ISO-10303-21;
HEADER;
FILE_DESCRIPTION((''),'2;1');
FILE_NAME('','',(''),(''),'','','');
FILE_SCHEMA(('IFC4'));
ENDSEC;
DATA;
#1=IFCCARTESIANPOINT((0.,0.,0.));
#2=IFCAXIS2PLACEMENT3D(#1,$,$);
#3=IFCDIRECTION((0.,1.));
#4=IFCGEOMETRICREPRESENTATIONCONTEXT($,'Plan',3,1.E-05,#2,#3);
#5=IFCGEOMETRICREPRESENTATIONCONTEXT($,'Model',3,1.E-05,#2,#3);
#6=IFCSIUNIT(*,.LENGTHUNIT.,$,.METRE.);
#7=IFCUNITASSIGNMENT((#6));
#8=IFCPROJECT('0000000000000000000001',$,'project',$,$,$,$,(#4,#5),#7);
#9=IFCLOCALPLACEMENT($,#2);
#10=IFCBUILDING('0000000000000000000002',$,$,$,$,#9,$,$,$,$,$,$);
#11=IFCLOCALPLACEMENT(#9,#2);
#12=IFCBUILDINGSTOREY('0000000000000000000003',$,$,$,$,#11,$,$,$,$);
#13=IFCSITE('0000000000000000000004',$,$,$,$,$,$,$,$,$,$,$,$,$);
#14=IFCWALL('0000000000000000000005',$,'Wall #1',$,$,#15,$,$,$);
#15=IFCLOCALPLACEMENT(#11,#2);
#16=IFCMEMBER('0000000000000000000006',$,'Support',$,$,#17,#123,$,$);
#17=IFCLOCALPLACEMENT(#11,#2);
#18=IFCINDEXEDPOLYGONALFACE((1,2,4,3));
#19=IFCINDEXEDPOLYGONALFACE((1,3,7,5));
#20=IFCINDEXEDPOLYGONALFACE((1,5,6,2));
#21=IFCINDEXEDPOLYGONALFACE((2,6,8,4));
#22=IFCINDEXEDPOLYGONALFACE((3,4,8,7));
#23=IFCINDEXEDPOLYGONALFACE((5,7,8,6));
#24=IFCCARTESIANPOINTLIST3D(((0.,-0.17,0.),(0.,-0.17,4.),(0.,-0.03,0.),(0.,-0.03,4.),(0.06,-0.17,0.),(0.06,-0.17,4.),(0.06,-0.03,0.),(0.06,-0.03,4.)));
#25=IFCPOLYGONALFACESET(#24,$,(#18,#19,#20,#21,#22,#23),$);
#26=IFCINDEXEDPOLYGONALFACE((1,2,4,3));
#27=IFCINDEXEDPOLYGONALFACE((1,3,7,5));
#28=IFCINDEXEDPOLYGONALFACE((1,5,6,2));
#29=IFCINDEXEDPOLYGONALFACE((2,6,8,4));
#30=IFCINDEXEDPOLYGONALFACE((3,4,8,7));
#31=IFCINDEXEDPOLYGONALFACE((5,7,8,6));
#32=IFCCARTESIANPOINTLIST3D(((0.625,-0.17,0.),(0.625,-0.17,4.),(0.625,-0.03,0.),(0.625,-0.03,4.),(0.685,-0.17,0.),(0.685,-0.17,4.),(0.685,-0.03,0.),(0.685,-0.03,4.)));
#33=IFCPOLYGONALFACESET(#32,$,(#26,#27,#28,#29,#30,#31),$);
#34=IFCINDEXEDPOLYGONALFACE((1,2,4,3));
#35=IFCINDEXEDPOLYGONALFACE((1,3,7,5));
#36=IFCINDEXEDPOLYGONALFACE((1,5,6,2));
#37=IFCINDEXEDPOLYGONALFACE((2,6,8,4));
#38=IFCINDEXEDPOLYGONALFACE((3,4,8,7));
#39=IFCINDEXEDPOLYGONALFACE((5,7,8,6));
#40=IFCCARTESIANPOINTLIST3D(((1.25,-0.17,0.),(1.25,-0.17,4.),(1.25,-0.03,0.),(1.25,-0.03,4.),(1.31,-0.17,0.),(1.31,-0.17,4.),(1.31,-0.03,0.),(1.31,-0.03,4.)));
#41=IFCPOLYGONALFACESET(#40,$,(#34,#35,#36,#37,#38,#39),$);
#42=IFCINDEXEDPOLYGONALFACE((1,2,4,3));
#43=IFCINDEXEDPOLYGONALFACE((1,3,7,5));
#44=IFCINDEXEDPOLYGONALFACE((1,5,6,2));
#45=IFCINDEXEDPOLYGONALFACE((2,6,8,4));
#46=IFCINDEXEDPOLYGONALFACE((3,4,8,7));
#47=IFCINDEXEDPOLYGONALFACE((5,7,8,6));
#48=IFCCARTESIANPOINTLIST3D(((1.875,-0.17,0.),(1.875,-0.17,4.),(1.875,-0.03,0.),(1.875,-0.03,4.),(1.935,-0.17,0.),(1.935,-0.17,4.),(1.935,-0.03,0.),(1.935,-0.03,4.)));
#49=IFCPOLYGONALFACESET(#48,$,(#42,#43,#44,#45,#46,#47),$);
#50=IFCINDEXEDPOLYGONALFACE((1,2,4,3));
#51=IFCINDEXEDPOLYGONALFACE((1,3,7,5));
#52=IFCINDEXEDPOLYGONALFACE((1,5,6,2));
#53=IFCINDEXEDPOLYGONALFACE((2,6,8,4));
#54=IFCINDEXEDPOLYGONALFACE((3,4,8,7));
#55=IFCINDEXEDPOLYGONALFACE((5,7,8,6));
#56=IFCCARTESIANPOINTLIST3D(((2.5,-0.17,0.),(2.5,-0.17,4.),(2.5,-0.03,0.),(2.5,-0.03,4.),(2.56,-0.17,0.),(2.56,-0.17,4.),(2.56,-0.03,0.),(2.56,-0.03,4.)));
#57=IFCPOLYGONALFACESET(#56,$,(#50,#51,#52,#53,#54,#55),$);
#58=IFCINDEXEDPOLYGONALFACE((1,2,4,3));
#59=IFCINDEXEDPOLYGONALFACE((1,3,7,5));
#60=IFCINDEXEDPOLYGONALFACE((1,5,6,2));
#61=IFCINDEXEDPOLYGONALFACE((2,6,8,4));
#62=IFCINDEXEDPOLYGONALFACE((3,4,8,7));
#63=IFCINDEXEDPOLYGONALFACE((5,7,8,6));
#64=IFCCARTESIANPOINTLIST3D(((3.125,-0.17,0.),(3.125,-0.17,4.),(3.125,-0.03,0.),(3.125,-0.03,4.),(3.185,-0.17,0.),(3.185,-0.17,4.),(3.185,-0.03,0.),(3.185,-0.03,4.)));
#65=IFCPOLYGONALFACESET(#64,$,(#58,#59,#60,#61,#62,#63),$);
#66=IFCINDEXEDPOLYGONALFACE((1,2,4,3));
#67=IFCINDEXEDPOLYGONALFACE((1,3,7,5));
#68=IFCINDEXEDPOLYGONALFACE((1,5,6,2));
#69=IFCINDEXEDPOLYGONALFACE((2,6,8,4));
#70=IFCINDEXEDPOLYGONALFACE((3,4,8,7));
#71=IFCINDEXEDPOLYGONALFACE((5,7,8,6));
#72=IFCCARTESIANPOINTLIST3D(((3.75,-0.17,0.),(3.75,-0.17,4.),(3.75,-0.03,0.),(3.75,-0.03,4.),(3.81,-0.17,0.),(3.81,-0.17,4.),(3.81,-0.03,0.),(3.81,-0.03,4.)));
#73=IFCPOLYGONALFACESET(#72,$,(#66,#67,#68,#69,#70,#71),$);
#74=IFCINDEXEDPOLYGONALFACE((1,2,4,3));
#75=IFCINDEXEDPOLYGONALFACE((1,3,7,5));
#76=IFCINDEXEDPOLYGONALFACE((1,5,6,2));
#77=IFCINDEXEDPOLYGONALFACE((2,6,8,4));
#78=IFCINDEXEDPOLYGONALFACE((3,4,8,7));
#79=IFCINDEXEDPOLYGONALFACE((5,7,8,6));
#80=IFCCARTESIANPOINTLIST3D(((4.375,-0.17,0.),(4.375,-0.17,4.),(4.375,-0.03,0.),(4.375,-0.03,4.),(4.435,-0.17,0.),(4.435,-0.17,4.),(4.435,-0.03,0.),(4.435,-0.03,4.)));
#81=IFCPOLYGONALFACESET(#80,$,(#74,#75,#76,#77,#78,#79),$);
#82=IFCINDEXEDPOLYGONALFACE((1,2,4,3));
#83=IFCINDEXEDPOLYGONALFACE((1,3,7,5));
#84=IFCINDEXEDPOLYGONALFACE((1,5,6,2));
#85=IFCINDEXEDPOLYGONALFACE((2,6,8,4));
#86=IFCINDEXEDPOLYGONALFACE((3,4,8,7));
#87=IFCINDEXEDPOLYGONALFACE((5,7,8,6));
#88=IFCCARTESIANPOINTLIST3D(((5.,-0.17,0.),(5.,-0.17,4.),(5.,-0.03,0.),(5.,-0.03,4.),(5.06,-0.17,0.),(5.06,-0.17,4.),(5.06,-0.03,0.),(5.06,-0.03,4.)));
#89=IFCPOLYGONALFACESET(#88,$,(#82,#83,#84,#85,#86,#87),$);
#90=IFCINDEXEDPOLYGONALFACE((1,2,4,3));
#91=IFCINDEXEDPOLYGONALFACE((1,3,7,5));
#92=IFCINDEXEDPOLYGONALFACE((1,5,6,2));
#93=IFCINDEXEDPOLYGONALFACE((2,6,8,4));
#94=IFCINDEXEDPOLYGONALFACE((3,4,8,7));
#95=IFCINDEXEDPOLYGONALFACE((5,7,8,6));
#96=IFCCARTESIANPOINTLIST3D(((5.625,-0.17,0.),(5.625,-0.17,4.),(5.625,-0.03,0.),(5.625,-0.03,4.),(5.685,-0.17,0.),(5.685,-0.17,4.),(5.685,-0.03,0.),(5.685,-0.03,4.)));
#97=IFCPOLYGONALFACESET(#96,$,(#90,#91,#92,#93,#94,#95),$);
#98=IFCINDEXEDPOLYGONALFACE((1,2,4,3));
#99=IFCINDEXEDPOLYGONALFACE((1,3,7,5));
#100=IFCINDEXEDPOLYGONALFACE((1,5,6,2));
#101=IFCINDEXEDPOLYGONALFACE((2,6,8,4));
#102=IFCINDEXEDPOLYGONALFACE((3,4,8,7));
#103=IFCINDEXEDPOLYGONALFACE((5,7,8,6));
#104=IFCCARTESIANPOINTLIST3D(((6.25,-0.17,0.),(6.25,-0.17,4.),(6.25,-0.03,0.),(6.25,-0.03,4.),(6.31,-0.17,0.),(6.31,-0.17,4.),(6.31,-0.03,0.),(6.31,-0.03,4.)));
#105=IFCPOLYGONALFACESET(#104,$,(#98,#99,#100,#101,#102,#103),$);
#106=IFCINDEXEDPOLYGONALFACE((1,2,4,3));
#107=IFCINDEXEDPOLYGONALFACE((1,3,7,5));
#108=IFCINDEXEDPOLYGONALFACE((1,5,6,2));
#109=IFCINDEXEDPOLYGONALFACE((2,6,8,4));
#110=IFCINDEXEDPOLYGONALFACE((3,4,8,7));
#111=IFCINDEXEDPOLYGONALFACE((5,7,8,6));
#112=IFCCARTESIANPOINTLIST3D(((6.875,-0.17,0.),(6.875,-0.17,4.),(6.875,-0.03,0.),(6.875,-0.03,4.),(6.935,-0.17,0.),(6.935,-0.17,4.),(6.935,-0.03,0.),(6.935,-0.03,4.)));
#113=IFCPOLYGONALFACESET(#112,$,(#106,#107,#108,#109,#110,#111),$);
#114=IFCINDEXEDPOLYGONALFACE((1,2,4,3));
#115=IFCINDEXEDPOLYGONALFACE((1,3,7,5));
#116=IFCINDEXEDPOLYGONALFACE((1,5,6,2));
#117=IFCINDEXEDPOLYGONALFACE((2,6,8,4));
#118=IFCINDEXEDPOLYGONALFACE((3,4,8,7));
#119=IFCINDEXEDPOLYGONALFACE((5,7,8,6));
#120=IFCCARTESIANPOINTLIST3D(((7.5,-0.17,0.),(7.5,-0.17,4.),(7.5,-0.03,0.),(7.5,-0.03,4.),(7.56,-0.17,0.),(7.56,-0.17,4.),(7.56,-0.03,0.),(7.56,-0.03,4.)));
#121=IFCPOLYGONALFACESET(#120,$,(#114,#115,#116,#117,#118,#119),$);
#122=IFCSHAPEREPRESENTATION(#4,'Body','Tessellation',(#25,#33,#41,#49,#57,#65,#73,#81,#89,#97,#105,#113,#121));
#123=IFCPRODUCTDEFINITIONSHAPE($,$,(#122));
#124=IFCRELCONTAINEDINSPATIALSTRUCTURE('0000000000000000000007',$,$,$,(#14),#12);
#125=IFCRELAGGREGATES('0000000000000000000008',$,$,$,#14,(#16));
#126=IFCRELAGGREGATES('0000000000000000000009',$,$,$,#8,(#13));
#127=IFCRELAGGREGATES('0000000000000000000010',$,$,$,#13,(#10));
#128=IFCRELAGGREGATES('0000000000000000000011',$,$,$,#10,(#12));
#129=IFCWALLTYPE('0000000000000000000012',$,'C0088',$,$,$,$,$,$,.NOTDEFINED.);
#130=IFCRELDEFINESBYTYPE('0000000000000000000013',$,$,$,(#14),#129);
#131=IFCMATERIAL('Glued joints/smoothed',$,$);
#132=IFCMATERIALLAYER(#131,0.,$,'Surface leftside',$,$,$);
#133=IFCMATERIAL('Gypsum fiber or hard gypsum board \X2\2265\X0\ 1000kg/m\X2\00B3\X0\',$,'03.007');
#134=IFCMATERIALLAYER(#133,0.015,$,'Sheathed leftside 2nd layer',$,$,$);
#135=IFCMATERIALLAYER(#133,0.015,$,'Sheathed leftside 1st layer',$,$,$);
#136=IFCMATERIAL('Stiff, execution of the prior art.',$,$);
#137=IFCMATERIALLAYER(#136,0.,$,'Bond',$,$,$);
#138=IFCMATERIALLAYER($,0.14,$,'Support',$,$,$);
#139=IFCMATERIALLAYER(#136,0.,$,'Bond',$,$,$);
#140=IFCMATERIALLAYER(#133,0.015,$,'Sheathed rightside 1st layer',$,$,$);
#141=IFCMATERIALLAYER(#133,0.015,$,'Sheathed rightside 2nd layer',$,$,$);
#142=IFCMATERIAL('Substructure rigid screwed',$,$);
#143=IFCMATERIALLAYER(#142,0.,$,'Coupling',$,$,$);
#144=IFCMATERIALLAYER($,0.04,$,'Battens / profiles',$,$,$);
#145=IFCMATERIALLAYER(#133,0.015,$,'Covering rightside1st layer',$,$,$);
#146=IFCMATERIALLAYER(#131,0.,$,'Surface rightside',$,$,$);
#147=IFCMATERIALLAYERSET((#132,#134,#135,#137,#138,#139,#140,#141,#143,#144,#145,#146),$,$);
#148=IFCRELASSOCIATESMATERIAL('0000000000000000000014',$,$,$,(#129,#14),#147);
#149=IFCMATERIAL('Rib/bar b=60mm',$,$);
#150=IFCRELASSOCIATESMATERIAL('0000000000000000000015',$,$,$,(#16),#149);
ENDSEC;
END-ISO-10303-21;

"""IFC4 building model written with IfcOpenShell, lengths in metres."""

from ifc_helpers import new_model, si_unit, direction, frame, frame_2d, origin, place, context, project, spatial, rectangle, extrude, material, layer, layer_set, type_object, element, aggregate, save


model = new_model("IFC4")

# Units and contexts
plan_context = context("Plan", 3, precision=1e-05, world=origin(), true_north=direction((0.0, 1.0)))
model_context = context("Model", 3, precision=1e-05, world=origin(), true_north=direction((0.0, 1.0)))
ifc_project = project(units=[si_unit("LENGTHUNIT", "METRE")], contexts=[plan_context, model_context])

# Site, building, storey
site = spatial("IfcSite", under=ifc_project)
building_placement = place(None, origin())
building = spatial("IfcBuilding", under=site, at=building_placement)
storey_placement = place(building_placement, origin())
storey = spatial("IfcBuildingStorey", under=building, at=storey_placement)

# Wall, member
ifc_material_1 = material(Name="Glued joints/smoothed")
ifc_layer_1 = layer(ifc_material_1, 0.0, Name="Surface leftside")
ifc_material_2 = material(Name="Gypsum fiber or hard gypsum board ≥ 1000kg/m³", Category="03.007")
ifc_layer_2 = layer(ifc_material_2, 0.015, Name="Sheathed leftside 2nd layer")
ifc_layer_3 = layer(ifc_material_2, 0.015, Name="Sheathed leftside 1st layer")
ifc_material_3 = material(Name="Stiff, execution of the prior art.")
ifc_layer_4 = layer(ifc_material_3, 0.0, Name="Bond")
ifc_layer_5 = layer(None, 0.14, Name="Support")
ifc_layer_6 = layer(ifc_material_3, 0.0, Name="Bond")
ifc_layer_7 = layer(ifc_material_2, 0.015, Name="Sheathed rightside 1st layer")
ifc_layer_8 = layer(ifc_material_2, 0.015, Name="Sheathed rightside 2nd layer")
ifc_material_4 = material(Name="Substructure rigid screwed")
ifc_layer_9 = layer(ifc_material_4, 0.0, Name="Coupling")
ifc_layer_10 = layer(None, 0.04, Name="Battens / profiles")
ifc_layer_11 = layer(ifc_material_2, 0.015, Name="Covering rightside1st layer")
ifc_layer_12 = layer(ifc_material_1, 0.0, Name="Surface rightside")
ifc_layer_set = layer_set([ifc_layer_1, ifc_layer_2, ifc_layer_3, ifc_layer_4, ifc_layer_5, ifc_layer_6, ifc_layer_7, ifc_layer_8, ifc_layer_9, ifc_layer_10, ifc_layer_11, ifc_layer_12])
wall_type = type_object("IfcWallType", Name="C0088", PredefinedType="NOTDEFINED", material=ifc_layer_set)
wall_placement = place(None, frame((0.0, 0.0, 0.0), z_axis=(0.0, -1.0, 0.0), x_axis=(1.0, 0.0, 0.0)))
wall = element("IfcWall", 1, at=wall_placement, inside=storey, type_object=wall_type, material=ifc_layer_set, Name="Wall #1")
ifc_material_5 = material(Name="Rib/bar b=60mm")
member_1_placement = place(wall_placement, origin())
member_1 = element("IfcMember", 2, at=member_1_placement, material=ifc_material_5, Name="Support", context=plan_context, shape_type="SweptSolid", body=[
    extrude(rectangle(XDim=0.06, YDim=0.14, at=frame_2d((0.03, 0.07), x_axis=(1.0, 0.0))), frame((0.0, 4.0, 0.03), z_axis=(0.0, -1.0, 0.0), x_axis=(1.0, 0.0, 0.0)), (0.0, 0.0, 1.0), 4.0),
    extrude(rectangle(XDim=0.06, YDim=0.14, at=frame_2d((0.03, 0.07), x_axis=(1.0, 0.0))), frame((0.625, 4.0, 0.03), z_axis=(0.0, -1.0, 0.0), x_axis=(1.0, 0.0, 0.0)), (0.0, 0.0, 1.0), 4.0),
    extrude(rectangle(XDim=0.06, YDim=0.14, at=frame_2d((0.03, 0.07), x_axis=(1.0, 0.0))), frame((1.25, 4.0, 0.03), z_axis=(0.0, -1.0, 0.0), x_axis=(1.0, 0.0, 0.0)), (0.0, 0.0, 1.0), 4.0),
    extrude(rectangle(XDim=0.06, YDim=0.14, at=frame_2d((0.03, 0.07), x_axis=(1.0, 0.0))), frame((1.875, 4.0, 0.03), z_axis=(0.0, -1.0, 0.0), x_axis=(1.0, 0.0, 0.0)), (0.0, 0.0, 1.0), 4.0),
    extrude(rectangle(XDim=0.06, YDim=0.14, at=frame_2d((0.03, 0.07), x_axis=(1.0, 0.0))), frame((2.5, 4.0, 0.03), z_axis=(0.0, -1.0, 0.0), x_axis=(1.0, 0.0, 0.0)), (0.0, 0.0, 1.0), 4.0),
    extrude(rectangle(XDim=0.06, YDim=0.14, at=frame_2d((0.03, 0.07), x_axis=(1.0, 0.0))), frame((3.125, 4.0, 0.03), z_axis=(0.0, -1.0, 0.0), x_axis=(1.0, 0.0, 0.0)), (0.0, 0.0, 1.0), 4.0),
    extrude(rectangle(XDim=0.06, YDim=0.14, at=frame_2d((0.03, 0.07), x_axis=(1.0, 0.0))), frame((3.75, 4.0, 0.03), z_axis=(0.0, -1.0, 0.0), x_axis=(1.0, 0.0, 0.0)), (0.0, 0.0, 1.0), 4.0),
    extrude(rectangle(XDim=0.06, YDim=0.14, at=frame_2d((0.03, 0.07), x_axis=(1.0, 0.0))), frame((4.375, 4.0, 0.03), z_axis=(0.0, -1.0, 0.0), x_axis=(1.0, 0.0, 0.0)), (0.0, 0.0, 1.0), 4.0),
    extrude(rectangle(XDim=0.06, YDim=0.14, at=frame_2d((0.03, 0.07), x_axis=(1.0, 0.0))), frame((5.0, 4.0, 0.03), z_axis=(0.0, -1.0, 0.0), x_axis=(1.0, 0.0, 0.0)), (0.0, 0.0, 1.0), 4.0),
    extrude(rectangle(XDim=0.06, YDim=0.14, at=frame_2d((0.03, 0.07), x_axis=(1.0, 0.0))), frame((5.625, 4.0, 0.03), z_axis=(0.0, -1.0, 0.0), x_axis=(1.0, 0.0, 0.0)), (0.0, 0.0, 1.0), 4.0),
    extrude(rectangle(XDim=0.06, YDim=0.14, at=frame_2d((0.03, 0.07), x_axis=(1.0, 0.0))), frame((6.25, 4.0, 0.03), z_axis=(0.0, -1.0, 0.0), x_axis=(1.0, 0.0, 0.0)), (0.0, 0.0, 1.0), 4.0),
    extrude(rectangle(XDim=0.06, YDim=0.14, at=frame_2d((0.03, 0.07), x_axis=(1.0, 0.0))), frame((6.875, 4.0, 0.03), z_axis=(0.0, -1.0, 0.0), x_axis=(1.0, 0.0, 0.0)), (0.0, 0.0, 1.0), 4.0),
    extrude(rectangle(XDim=0.06, YDim=0.14, at=frame_2d((0.03, 0.07), x_axis=(1.0, 0.0))), frame((7.5, 4.0, 0.03), z_axis=(0.0, -1.0, 0.0), x_axis=(1.0, 0.0, 0.0)), (0.0, 0.0, 1.0), 4.0),
])
aggregate(wall, [member_1])

save(model, "model.ifc")
